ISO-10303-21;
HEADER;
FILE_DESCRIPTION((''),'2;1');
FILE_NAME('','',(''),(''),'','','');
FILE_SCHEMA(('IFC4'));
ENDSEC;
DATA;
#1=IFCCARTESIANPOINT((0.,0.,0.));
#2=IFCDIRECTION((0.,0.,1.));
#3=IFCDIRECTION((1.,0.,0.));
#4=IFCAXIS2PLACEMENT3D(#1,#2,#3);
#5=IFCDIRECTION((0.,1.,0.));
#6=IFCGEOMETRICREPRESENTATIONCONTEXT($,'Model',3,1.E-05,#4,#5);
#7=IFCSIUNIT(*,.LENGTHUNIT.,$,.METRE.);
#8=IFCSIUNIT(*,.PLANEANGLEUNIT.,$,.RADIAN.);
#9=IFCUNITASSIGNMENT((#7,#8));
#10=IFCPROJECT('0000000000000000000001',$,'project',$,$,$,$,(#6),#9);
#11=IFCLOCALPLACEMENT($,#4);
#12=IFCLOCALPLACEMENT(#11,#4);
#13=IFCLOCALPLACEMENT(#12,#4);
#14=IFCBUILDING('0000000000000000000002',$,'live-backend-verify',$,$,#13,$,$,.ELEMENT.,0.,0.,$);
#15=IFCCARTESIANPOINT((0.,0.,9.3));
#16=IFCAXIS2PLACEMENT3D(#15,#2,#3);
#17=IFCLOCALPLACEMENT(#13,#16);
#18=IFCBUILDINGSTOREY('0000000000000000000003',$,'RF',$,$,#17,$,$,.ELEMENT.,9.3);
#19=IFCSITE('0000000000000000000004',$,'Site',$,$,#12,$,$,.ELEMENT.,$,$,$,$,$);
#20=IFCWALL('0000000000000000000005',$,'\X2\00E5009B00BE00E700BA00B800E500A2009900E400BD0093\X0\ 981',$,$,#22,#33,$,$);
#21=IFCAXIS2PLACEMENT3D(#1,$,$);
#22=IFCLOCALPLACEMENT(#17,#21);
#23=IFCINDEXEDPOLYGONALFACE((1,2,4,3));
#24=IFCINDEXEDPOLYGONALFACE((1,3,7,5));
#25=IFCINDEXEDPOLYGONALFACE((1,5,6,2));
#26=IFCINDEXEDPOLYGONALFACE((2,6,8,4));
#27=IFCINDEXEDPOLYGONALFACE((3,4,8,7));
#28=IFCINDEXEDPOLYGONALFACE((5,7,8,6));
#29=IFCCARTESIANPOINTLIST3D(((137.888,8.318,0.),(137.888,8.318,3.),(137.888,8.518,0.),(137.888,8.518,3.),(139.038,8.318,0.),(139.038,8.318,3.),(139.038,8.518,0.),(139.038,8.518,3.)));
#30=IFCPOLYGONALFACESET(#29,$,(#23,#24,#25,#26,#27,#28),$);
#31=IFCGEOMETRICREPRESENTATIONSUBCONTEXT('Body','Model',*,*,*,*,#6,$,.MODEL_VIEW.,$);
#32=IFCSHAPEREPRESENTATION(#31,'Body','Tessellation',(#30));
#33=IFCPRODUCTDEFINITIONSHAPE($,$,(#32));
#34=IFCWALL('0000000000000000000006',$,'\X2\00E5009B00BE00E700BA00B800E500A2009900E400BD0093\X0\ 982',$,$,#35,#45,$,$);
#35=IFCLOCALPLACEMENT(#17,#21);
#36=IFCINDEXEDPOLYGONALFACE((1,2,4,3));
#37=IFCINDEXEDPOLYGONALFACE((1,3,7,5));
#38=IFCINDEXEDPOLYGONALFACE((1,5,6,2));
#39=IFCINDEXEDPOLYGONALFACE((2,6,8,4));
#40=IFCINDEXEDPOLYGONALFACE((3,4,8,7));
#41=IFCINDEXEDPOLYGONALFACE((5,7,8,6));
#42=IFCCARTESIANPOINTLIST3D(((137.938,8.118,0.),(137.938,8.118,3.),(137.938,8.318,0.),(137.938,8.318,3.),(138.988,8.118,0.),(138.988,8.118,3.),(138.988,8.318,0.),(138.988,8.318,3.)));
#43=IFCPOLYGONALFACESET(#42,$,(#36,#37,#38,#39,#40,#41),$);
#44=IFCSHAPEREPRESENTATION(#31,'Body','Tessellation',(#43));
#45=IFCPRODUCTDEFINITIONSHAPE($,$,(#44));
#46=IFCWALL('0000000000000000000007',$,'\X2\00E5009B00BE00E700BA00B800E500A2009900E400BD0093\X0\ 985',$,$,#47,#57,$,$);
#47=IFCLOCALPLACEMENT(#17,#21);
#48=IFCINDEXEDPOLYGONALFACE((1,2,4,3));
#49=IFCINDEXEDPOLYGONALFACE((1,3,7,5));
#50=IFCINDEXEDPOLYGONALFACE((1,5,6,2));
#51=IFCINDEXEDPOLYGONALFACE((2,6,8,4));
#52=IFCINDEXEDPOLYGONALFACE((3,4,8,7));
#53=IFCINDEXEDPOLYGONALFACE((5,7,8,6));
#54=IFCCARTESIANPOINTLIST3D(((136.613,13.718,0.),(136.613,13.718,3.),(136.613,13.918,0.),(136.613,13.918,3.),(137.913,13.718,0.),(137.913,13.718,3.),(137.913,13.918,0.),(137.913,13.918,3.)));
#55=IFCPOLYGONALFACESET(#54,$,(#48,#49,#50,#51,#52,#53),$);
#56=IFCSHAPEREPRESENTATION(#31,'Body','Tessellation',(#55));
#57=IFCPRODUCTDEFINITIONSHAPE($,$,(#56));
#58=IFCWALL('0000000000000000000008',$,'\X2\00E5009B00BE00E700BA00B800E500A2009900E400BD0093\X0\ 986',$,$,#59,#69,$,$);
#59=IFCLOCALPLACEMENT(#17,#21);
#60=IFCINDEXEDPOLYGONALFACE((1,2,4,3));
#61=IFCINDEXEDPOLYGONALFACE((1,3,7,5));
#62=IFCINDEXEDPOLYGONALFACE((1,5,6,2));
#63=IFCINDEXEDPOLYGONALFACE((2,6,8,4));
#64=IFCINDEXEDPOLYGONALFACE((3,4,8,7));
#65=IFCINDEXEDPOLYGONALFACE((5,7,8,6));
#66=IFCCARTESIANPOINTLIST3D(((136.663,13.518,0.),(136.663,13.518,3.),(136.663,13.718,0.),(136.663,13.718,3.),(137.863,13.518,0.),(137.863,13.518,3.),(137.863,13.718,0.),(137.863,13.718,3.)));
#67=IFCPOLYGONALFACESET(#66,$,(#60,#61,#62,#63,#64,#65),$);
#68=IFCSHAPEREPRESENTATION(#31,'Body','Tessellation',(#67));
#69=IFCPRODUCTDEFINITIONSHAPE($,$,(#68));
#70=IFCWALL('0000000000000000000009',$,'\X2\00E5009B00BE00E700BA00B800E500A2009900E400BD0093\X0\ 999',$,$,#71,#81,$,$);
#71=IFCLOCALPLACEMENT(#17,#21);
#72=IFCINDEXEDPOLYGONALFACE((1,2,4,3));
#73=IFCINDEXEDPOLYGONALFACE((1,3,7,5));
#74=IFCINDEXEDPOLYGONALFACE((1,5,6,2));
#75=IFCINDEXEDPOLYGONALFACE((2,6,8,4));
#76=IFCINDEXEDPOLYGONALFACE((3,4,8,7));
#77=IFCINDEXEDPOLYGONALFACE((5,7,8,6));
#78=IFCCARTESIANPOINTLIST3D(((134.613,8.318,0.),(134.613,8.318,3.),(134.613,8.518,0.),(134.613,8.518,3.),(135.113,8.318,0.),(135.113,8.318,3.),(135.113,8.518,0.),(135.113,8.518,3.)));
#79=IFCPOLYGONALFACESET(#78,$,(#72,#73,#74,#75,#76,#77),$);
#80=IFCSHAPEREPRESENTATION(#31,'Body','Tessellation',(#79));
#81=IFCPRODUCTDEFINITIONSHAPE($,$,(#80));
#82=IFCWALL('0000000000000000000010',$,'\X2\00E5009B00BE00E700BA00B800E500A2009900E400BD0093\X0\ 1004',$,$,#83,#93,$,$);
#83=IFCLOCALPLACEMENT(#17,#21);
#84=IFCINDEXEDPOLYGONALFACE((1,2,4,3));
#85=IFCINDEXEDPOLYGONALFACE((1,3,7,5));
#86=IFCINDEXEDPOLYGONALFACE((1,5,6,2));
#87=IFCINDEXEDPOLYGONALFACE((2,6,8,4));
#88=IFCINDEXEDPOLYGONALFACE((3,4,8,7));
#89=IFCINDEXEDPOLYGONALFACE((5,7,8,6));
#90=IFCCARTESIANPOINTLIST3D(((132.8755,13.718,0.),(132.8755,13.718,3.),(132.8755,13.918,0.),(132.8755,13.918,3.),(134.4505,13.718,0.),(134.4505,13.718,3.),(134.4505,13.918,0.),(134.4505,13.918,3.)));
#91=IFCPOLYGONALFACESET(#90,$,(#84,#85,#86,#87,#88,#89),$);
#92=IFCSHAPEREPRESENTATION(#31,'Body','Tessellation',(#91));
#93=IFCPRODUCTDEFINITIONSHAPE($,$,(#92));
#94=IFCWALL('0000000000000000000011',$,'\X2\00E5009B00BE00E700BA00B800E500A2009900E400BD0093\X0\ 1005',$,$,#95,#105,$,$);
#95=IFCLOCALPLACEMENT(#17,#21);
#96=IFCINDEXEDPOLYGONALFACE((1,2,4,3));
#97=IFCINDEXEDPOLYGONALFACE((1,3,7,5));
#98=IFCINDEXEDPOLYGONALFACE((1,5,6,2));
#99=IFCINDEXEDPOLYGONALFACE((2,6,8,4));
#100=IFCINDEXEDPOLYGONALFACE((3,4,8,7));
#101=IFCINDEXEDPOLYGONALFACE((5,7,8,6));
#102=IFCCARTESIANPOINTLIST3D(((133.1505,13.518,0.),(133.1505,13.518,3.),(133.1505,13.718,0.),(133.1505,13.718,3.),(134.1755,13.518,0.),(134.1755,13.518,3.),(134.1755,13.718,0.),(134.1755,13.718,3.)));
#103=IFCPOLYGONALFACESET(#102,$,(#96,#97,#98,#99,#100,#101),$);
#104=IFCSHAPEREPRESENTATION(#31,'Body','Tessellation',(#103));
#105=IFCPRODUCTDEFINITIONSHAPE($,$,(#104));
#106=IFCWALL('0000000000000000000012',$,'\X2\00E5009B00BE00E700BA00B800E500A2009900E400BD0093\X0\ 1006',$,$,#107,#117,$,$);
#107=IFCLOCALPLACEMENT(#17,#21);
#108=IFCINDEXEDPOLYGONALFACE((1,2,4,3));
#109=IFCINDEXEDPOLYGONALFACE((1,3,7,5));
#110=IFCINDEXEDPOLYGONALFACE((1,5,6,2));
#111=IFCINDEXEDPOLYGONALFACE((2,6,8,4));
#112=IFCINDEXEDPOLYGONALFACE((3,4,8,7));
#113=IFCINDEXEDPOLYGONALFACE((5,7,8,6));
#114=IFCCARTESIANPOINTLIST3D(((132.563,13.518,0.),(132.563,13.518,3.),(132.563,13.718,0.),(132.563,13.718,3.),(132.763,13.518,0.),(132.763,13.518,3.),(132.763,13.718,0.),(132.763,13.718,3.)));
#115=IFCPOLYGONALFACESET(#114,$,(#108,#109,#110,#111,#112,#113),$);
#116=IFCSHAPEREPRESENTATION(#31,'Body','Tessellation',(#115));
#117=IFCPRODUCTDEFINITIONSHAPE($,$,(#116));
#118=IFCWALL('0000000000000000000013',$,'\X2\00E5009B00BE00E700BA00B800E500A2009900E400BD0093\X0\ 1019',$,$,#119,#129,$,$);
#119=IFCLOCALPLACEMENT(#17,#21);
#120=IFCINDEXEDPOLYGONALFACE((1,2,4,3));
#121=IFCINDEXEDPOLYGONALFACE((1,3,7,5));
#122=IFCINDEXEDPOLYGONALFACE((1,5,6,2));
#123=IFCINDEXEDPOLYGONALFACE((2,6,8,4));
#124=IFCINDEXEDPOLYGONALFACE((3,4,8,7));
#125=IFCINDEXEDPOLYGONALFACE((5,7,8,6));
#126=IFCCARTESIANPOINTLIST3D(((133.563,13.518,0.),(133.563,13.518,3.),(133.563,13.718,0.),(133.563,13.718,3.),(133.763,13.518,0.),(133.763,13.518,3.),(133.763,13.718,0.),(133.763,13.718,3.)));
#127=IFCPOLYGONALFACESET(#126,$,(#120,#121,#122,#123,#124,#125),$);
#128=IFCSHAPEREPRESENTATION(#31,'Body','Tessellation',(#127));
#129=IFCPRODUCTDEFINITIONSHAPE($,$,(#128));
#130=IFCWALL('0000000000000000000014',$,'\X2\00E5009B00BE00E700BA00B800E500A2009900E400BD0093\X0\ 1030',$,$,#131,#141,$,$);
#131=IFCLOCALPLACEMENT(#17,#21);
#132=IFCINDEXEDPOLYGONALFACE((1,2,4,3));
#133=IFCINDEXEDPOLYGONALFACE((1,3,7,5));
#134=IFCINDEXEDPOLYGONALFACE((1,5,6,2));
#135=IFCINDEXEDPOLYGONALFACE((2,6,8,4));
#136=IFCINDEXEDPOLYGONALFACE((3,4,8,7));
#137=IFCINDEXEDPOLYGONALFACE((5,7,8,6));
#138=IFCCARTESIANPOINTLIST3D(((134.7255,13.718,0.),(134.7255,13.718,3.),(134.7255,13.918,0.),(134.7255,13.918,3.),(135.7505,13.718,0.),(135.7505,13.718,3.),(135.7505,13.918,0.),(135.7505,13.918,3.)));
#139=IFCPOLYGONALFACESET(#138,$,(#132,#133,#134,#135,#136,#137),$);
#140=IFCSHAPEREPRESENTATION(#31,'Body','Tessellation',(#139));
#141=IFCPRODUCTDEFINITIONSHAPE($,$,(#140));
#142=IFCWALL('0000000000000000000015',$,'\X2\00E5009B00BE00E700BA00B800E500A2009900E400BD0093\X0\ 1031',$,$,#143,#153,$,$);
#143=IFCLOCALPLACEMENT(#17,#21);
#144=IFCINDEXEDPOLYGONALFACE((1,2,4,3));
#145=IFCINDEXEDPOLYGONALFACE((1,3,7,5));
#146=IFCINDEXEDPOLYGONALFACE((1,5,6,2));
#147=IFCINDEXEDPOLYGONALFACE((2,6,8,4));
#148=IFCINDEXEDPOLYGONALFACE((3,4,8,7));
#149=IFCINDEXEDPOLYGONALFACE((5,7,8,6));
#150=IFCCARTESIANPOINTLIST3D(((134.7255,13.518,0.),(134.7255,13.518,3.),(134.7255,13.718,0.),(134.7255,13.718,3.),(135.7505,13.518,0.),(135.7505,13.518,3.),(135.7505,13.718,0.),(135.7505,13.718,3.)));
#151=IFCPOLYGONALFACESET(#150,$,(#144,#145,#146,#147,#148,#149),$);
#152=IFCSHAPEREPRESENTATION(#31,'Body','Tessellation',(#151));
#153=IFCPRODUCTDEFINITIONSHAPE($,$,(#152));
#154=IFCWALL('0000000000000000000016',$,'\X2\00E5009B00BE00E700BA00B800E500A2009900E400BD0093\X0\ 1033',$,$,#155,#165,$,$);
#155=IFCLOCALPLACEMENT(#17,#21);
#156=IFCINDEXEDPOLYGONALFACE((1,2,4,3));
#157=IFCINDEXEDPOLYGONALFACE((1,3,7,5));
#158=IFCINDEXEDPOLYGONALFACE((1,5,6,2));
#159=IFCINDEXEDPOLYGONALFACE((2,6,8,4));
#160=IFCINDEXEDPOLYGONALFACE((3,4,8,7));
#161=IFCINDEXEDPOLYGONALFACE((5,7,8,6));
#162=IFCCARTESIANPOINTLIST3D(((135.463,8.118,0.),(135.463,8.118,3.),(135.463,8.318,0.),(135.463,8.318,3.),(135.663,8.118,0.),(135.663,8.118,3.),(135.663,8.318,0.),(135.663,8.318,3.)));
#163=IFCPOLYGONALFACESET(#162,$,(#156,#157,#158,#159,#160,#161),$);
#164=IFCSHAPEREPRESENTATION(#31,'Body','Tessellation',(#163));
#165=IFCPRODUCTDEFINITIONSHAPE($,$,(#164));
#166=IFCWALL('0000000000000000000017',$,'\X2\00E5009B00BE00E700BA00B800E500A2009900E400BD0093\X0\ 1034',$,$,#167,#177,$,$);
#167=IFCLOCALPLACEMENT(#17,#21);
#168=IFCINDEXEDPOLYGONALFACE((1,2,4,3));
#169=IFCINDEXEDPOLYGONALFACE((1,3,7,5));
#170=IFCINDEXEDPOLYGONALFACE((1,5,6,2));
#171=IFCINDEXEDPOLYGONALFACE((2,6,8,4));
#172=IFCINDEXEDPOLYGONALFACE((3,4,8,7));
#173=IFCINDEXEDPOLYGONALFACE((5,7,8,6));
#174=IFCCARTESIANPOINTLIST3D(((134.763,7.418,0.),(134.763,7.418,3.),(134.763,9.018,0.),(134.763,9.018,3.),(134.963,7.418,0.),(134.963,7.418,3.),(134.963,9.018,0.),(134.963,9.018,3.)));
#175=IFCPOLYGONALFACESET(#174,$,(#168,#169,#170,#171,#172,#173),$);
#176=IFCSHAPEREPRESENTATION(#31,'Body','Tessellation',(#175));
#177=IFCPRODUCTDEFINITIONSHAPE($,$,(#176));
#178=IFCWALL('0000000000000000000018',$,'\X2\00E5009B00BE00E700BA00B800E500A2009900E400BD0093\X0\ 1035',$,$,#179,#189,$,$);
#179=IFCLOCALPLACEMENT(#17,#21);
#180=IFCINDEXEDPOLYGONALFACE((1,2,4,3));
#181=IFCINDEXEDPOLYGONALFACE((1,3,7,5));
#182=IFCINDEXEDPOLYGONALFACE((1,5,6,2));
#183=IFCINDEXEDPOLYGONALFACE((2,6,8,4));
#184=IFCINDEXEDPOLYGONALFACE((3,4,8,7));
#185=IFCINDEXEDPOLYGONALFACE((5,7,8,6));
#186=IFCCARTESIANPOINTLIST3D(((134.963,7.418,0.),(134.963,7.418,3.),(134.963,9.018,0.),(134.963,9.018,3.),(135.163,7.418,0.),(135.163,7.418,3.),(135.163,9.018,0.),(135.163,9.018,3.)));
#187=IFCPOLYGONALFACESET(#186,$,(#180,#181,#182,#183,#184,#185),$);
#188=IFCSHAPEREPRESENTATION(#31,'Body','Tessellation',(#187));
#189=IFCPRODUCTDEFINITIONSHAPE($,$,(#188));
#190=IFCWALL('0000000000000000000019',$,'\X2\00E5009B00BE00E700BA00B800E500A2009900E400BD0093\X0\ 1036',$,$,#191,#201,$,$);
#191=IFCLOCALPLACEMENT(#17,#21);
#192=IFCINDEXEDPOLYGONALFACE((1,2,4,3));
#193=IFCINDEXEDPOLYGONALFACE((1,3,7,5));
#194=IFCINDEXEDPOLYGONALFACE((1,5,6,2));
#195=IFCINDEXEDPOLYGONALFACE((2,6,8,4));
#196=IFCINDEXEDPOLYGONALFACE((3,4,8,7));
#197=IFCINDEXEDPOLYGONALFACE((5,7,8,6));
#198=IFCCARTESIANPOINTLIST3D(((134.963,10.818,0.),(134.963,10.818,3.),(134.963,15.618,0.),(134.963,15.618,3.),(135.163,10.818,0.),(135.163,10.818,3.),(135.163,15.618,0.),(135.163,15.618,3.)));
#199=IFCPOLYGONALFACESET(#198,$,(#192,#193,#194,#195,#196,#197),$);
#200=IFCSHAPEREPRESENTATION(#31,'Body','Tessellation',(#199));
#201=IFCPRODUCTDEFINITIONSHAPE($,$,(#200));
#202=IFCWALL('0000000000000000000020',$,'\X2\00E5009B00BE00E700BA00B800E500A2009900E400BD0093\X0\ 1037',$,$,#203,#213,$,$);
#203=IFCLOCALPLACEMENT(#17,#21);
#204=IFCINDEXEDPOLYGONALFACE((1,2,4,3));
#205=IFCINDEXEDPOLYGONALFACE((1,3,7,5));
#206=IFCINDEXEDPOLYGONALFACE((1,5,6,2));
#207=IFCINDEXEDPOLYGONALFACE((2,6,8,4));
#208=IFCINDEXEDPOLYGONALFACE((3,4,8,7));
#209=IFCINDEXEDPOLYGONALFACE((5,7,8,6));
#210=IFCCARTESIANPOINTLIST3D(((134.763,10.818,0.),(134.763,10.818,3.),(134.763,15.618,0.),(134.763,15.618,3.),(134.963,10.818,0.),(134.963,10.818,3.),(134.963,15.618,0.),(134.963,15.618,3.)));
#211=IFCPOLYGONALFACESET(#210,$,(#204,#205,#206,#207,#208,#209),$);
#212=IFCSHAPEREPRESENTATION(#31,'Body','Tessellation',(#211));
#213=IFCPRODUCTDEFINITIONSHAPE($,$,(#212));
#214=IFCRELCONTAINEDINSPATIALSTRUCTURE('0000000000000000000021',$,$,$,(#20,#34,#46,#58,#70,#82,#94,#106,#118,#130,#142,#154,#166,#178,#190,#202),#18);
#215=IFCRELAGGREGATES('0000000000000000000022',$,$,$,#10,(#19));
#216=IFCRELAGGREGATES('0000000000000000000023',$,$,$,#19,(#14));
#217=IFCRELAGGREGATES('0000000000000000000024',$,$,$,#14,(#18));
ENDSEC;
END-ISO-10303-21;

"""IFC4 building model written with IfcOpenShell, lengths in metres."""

from ifc_helpers import new_model, si_unit, direction, frame, frame_2d, origin_with_axes, place, context, subcontext, project, spatial, rectangle, extrude, element, save


model = new_model("IFC4")

# Units and contexts
model_context = context("Model", 3, precision=1e-05, world=origin_with_axes(), true_north=direction((0.0, 1.0, 0.0)))
body_context = subcontext(model_context, "Body", "Model", "MODEL_VIEW")
ifc_project = project(units=[si_unit("LENGTHUNIT", "METRE"), si_unit("PLANEANGLEUNIT", "RADIAN")], contexts=[model_context])

# Site, building, storey
placement = place(None, origin_with_axes())
site_placement = place(placement, origin_with_axes())
site = spatial("IfcSite", under=ifc_project, at=site_placement, Name="Site", CompositionType="ELEMENT")
building_placement = place(site_placement, origin_with_axes())
building = spatial("IfcBuilding", under=site, at=building_placement, Name="live-backend-verify", CompositionType="ELEMENT", ElevationOfRefHeight=0.0, ElevationOfTerrain=0.0)
storey_placement = place(building_placement, frame((0.0, 0.0, 9.3), z_axis=(0.0, 0.0, 1.0), x_axis=(1.0, 0.0, 0.0)))
storey = spatial("IfcBuildingStorey", under=building, at=storey_placement, Name="RF", CompositionType="ELEMENT", Elevation=9.3)

# Walls
wall_1_placement = place(storey_placement, frame((138.463, 8.418, 0.0), z_axis=(0.0, 0.0, 1.0), x_axis=(-1.0, 0.0, 0.0)))
element("IfcWall", 1, at=wall_1_placement, inside=storey, Name="å\u009b¾çº¸å¢\u0099ä½\u0093 981", context=body_context, shape_type="SweptSolid", body=[
    extrude(rectangle(XDim=1.15, YDim=0.2, at=frame_2d((0.0, 0.0), x_axis=(1.0, 0.0, 0.0))), frame((0.0, 0.0, 0.0), z_axis=(0.0, 0.0, 1.0)), (0.0, 0.0, 1.0), 3.0),
])
wall_2_placement = place(storey_placement, frame((138.463, 8.218, 0.0), z_axis=(0.0, 0.0, 1.0), x_axis=(-1.0, 0.0, 0.0)))
element("IfcWall", 2, at=wall_2_placement, inside=storey, Name="å\u009b¾çº¸å¢\u0099ä½\u0093 982", context=body_context, shape_type="SweptSolid", body=[
    extrude(rectangle(XDim=1.05, YDim=0.2, at=frame_2d((0.0, 0.0), x_axis=(1.0, 0.0, 0.0))), frame((0.0, 0.0, 0.0), z_axis=(0.0, 0.0, 1.0)), (0.0, 0.0, 1.0), 3.0),
])
wall_3_placement = place(storey_placement, frame((137.263, 13.818, 0.0), z_axis=(0.0, 0.0, 1.0), x_axis=(1.0, 0.0, 0.0)))
element("IfcWall", 3, at=wall_3_placement, inside=storey, Name="å\u009b¾çº¸å¢\u0099ä½\u0093 985", context=body_context, shape_type="SweptSolid", body=[
    extrude(rectangle(XDim=1.3, YDim=0.2, at=frame_2d((0.0, 0.0), x_axis=(1.0, 0.0, 0.0))), frame((0.0, 0.0, 0.0), z_axis=(0.0, 0.0, 1.0)), (0.0, 0.0, 1.0), 3.0),
])
wall_4_placement = place(storey_placement, frame((137.263, 13.618, 0.0), z_axis=(0.0, 0.0, 1.0), x_axis=(1.0, 0.0, 0.0)))
element("IfcWall", 4, at=wall_4_placement, inside=storey, Name="å\u009b¾çº¸å¢\u0099ä½\u0093 986", context=body_context, shape_type="SweptSolid", body=[
    extrude(rectangle(XDim=1.2, YDim=0.2, at=frame_2d((0.0, 0.0), x_axis=(1.0, 0.0, 0.0))), frame((0.0, 0.0, 0.0), z_axis=(0.0, 0.0, 1.0)), (0.0, 0.0, 1.0), 3.0),
])
wall_5_placement = place(storey_placement, frame((134.863, 8.418, 0.0), z_axis=(0.0, 0.0, 1.0), x_axis=(-1.0, 0.0, 0.0)))
element("IfcWall", 5, at=wall_5_placement, inside=storey, Name="å\u009b¾çº¸å¢\u0099ä½\u0093 999", context=body_context, shape_type="SweptSolid", body=[
    extrude(rectangle(XDim=0.5, YDim=0.2, at=frame_2d((0.0, 0.0), x_axis=(1.0, 0.0, 0.0))), frame((0.0, 0.0, 0.0), z_axis=(0.0, 0.0, 1.0)), (0.0, 0.0, 1.0), 3.0),
])
wall_6_placement = place(storey_placement, frame((133.663, 13.818, 0.0), z_axis=(0.0, 0.0, 1.0), x_axis=(1.0, 0.0, 0.0)))
element("IfcWall", 6, at=wall_6_placement, inside=storey, Name="å\u009b¾çº¸å¢\u0099ä½\u0093 1004", context=body_context, shape_type="SweptSolid", body=[
    extrude(rectangle(XDim=1.575, YDim=0.2, at=frame_2d((0.0, 0.0), x_axis=(1.0, 0.0, 0.0))), frame((0.0, 0.0, 0.0), z_axis=(0.0, 0.0, 1.0)), (0.0, 0.0, 1.0), 3.0),
])
wall_7_placement = place(storey_placement, frame((133.663, 13.618, 0.0), z_axis=(0.0, 0.0, 1.0), x_axis=(1.0, 0.0, 0.0)))
element("IfcWall", 7, at=wall_7_placement, inside=storey, Name="å\u009b¾çº¸å¢\u0099ä½\u0093 1005", context=body_context, shape_type="SweptSolid", body=[
    extrude(rectangle(XDim=1.025, YDim=0.2, at=frame_2d((0.0, 0.0), x_axis=(1.0, 0.0, 0.0))), frame((0.0, 0.0, 0.0), z_axis=(0.0, 0.0, 1.0)), (0.0, 0.0, 1.0), 3.0),
])
for number, where, z_axis, x_axis, name in (
    (8, (132.663, 13.618, 0.0), (0.0, 0.0, 1.0), (0.0, 1.0, 0.0), "å\u009b¾çº¸å¢\u0099ä½\u0093 1006"),
    (9, (133.663, 13.618, 0.0), (0.0, 0.0, 1.0), (0.0, 1.0, 0.0), "å\u009b¾çº¸å¢\u0099ä½\u0093 1019"),
):
    element("IfcWall", number, at=place(storey_placement, frame(where, z_axis=z_axis, x_axis=x_axis)), inside=storey, Name=name, context=body_context, shape_type="SweptSolid", body=[
        extrude(rectangle(XDim=0.2, YDim=0.2, at=frame_2d((0.0, 0.0), x_axis=(1.0, 0.0, 0.0))), frame((0.0, 0.0, 0.0), z_axis=(0.0, 0.0, 1.0)), (0.0, 0.0, 1.0), 3.0),
    ])
for number, where, z_axis, x_axis, name in (
    (10, (135.238, 13.818, 0.0), (0.0, 0.0, 1.0), (1.0, 0.0, 0.0), "å\u009b¾çº¸å¢\u0099ä½\u0093 1030"),
    (11, (135.238, 13.618, 0.0), (0.0, 0.0, 1.0), (1.0, 0.0, 0.0), "å\u009b¾çº¸å¢\u0099ä½\u0093 1031"),
):
    element("IfcWall", number, at=place(storey_placement, frame(where, z_axis=z_axis, x_axis=x_axis)), inside=storey, Name=name, context=body_context, shape_type="SweptSolid", body=[
        extrude(rectangle(XDim=1.025, YDim=0.2, at=frame_2d((0.0, 0.0), x_axis=(1.0, 0.0, 0.0))), frame((0.0, 0.0, 0.0), z_axis=(0.0, 0.0, 1.0)), (0.0, 0.0, 1.0), 3.0),
    ])
wall_8_placement = place(storey_placement, frame((135.563, 8.218, 0.0), z_axis=(0.0, 0.0, 1.0), x_axis=(0.0, 1.0, 0.0)))
element("IfcWall", 12, at=wall_8_placement, inside=storey, Name="å\u009b¾çº¸å¢\u0099ä½\u0093 1033", context=body_context, shape_type="SweptSolid", body=[
    extrude(rectangle(XDim=0.2, YDim=0.2, at=frame_2d((0.0, 0.0), x_axis=(1.0, 0.0, 0.0))), frame((0.0, 0.0, 0.0), z_axis=(0.0, 0.0, 1.0)), (0.0, 0.0, 1.0), 3.0),
])
for number, where, z_axis, x_axis, name in (
    (13, (134.863, 8.218, 0.0), (0.0, 0.0, 1.0), (0.0, -1.0, 0.0), "å\u009b¾çº¸å¢\u0099ä½\u0093 1034"),
    (14, (135.063, 8.218, 0.0), (0.0, 0.0, 1.0), (0.0, -1.0, 0.0), "å\u009b¾çº¸å¢\u0099ä½\u0093 1035"),
):
    element("IfcWall", number, at=place(storey_placement, frame(where, z_axis=z_axis, x_axis=x_axis)), inside=storey, Name=name, context=body_context, shape_type="SweptSolid", body=[
        extrude(rectangle(XDim=1.6, YDim=0.2, at=frame_2d((0.0, 0.0), x_axis=(1.0, 0.0, 0.0))), frame((0.0, 0.0, 0.0), z_axis=(0.0, 0.0, 1.0)), (0.0, 0.0, 1.0), 3.0),
    ])
for number, where, z_axis, x_axis, name in (
    (15, (135.063, 13.218, 0.0), (0.0, 0.0, 1.0), (0.0, -1.0, 0.0), "å\u009b¾çº¸å¢\u0099ä½\u0093 1036"),
    (16, (134.863, 13.218, 0.0), (0.0, 0.0, 1.0), (0.0, -1.0, 0.0), "å\u009b¾çº¸å¢\u0099ä½\u0093 1037"),
):
    element("IfcWall", number, at=place(storey_placement, frame(where, z_axis=z_axis, x_axis=x_axis)), inside=storey, Name=name, context=body_context, shape_type="SweptSolid", body=[
        extrude(rectangle(XDim=4.8, YDim=0.2, at=frame_2d((0.0, 0.0), x_axis=(1.0, 0.0, 0.0))), frame((0.0, 0.0, 0.0), z_axis=(0.0, 0.0, 1.0)), (0.0, 0.0, 1.0), 3.0),
    ])

save(model, "model.ifc")
